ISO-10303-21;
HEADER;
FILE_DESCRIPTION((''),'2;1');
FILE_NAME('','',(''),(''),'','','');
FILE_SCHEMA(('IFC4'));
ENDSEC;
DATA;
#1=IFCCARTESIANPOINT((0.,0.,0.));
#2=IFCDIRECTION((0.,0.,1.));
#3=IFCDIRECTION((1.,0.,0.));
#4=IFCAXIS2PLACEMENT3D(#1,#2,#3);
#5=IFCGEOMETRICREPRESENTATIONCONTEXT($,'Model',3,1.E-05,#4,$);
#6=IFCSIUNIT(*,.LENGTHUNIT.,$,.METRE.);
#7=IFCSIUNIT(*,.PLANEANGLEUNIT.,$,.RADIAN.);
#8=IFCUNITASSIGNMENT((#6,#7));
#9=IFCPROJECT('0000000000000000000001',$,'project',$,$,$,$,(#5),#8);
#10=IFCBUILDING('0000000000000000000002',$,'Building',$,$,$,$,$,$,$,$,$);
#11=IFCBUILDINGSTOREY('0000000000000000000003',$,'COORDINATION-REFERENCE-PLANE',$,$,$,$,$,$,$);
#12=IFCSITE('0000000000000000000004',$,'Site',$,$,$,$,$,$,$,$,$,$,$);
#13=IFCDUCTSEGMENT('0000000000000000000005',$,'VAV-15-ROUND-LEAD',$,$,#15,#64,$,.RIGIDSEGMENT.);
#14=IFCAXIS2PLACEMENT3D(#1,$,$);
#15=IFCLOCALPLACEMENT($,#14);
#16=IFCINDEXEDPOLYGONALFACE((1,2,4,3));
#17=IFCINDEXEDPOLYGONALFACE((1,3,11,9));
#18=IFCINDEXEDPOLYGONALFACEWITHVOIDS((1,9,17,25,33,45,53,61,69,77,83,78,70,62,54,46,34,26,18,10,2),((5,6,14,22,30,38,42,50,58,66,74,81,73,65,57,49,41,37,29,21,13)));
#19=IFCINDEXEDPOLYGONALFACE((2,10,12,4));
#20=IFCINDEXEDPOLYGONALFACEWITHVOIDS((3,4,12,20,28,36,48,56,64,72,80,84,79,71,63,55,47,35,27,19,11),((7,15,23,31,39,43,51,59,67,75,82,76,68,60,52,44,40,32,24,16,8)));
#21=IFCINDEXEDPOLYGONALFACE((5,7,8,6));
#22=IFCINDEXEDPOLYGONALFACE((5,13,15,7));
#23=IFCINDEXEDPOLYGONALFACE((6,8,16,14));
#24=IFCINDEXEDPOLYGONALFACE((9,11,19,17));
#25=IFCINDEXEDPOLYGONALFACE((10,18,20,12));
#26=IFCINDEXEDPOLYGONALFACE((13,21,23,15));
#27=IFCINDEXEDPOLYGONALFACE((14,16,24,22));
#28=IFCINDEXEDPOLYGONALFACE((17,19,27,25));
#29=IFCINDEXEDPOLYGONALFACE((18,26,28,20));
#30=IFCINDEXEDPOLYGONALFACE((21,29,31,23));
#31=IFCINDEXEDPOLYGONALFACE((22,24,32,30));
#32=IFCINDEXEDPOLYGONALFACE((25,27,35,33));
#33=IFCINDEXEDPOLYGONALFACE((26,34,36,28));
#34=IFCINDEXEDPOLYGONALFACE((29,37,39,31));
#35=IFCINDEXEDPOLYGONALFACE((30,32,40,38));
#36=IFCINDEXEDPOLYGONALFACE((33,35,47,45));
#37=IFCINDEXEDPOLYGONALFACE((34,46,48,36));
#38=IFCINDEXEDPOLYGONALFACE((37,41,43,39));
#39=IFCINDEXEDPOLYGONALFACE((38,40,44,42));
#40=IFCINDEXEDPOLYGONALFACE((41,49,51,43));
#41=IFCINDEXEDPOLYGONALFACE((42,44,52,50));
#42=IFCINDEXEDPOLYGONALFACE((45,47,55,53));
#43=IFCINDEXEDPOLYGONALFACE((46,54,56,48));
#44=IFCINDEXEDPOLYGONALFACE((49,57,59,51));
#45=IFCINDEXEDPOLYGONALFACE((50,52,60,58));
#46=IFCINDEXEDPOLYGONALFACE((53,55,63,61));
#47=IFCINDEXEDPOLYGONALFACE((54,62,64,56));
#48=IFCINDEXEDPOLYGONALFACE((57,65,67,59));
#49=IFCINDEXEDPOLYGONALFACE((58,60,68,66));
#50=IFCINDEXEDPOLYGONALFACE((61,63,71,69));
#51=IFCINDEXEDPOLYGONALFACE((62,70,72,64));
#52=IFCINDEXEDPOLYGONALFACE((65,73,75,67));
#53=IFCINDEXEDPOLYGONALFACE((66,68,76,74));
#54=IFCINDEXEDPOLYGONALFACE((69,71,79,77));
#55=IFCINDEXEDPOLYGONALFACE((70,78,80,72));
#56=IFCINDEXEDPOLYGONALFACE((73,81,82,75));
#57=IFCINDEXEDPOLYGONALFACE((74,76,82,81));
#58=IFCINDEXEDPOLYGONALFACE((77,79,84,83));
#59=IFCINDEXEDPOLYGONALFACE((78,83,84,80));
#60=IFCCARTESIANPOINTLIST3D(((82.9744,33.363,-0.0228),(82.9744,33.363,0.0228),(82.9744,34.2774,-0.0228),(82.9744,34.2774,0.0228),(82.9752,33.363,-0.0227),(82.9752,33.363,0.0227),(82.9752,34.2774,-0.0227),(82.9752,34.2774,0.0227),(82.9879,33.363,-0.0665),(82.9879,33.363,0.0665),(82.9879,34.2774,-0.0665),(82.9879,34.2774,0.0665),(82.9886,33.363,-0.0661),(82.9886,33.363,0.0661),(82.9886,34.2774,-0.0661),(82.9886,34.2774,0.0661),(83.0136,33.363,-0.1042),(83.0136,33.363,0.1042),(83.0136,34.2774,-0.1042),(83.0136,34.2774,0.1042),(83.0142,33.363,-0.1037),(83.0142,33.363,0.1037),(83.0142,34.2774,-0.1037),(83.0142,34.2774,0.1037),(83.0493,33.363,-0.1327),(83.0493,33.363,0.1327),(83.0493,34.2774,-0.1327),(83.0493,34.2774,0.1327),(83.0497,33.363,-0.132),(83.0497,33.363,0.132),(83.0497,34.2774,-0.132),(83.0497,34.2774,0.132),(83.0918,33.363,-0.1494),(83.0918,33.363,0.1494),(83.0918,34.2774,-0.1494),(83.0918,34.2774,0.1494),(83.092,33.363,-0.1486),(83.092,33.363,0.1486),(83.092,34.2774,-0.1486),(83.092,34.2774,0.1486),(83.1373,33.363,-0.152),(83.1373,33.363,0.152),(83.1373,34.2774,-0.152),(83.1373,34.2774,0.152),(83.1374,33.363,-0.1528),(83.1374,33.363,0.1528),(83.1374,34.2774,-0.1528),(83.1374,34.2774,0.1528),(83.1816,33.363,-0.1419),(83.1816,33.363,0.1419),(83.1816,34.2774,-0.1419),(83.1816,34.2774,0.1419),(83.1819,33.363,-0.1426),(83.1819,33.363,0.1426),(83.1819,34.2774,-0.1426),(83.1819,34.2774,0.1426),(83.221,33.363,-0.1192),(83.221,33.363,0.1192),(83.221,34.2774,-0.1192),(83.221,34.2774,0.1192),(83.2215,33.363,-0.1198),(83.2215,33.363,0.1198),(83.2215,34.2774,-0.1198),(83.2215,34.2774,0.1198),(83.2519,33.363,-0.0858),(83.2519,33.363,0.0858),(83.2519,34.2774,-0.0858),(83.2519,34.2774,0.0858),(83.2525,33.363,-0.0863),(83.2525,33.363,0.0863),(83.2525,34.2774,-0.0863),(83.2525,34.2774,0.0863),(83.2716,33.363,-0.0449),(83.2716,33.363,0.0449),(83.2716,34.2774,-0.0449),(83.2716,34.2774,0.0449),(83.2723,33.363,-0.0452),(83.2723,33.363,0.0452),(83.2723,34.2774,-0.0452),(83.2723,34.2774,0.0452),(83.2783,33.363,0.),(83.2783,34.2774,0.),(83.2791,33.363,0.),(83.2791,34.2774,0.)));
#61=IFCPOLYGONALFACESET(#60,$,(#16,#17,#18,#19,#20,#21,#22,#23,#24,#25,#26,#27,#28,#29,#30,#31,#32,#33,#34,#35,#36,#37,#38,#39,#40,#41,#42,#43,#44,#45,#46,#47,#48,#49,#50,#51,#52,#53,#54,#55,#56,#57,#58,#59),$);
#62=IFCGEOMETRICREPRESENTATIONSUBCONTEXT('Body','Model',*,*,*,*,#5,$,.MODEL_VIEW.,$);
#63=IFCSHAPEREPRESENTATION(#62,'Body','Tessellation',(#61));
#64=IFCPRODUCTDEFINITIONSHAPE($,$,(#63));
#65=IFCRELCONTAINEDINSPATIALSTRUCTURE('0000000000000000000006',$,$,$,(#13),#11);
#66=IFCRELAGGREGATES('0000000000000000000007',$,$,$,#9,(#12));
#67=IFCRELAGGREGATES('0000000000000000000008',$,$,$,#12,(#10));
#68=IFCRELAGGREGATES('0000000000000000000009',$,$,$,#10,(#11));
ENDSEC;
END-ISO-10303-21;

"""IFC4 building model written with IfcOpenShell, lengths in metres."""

from ifc_helpers import new_model, si_unit, frame, origin, origin_with_axes, place, context, subcontext, project, spatial, hollow_circle, extrude, element, save


model = new_model("IFC4")

# Units and contexts
model_context = context("Model", 3, precision=1e-05, world=origin_with_axes())
body_context_1 = subcontext(model_context, "Body", "Model", "MODEL_VIEW")
ifc_project = project(units=[si_unit("LENGTHUNIT", "METRE"), si_unit("PLANEANGLEUNIT", "RADIAN")], contexts=[model_context])

# Site, building, storey
site = spatial("IfcSite", under=ifc_project, Name="Site")
building = spatial("IfcBuilding", under=site, Name="Building")
storey = spatial("IfcBuildingStorey", under=building, Name="COORDINATION-REFERENCE-PLANE")

# Duct segment
duct_segment_1_placement = place(None, frame((83.1259, 34.2774, 0.0), z_axis=(0.0, -1.0, 0.0), x_axis=(1.0, 0.0, 0.0)))
element("IfcDuctSegment", 1, at=duct_segment_1_placement, inside=storey, Name="VAV-15-ROUND-LEAD", PredefinedType="RIGIDSEGMENT", context=body_context_1, shape_type="SweptSolid", body=[
    extrude(hollow_circle(Radius=0.1532, WallThickness=0.0008), origin(), (0.0, 0.0, 1.0), 0.9144),
])

save(model, "model.ifc")
